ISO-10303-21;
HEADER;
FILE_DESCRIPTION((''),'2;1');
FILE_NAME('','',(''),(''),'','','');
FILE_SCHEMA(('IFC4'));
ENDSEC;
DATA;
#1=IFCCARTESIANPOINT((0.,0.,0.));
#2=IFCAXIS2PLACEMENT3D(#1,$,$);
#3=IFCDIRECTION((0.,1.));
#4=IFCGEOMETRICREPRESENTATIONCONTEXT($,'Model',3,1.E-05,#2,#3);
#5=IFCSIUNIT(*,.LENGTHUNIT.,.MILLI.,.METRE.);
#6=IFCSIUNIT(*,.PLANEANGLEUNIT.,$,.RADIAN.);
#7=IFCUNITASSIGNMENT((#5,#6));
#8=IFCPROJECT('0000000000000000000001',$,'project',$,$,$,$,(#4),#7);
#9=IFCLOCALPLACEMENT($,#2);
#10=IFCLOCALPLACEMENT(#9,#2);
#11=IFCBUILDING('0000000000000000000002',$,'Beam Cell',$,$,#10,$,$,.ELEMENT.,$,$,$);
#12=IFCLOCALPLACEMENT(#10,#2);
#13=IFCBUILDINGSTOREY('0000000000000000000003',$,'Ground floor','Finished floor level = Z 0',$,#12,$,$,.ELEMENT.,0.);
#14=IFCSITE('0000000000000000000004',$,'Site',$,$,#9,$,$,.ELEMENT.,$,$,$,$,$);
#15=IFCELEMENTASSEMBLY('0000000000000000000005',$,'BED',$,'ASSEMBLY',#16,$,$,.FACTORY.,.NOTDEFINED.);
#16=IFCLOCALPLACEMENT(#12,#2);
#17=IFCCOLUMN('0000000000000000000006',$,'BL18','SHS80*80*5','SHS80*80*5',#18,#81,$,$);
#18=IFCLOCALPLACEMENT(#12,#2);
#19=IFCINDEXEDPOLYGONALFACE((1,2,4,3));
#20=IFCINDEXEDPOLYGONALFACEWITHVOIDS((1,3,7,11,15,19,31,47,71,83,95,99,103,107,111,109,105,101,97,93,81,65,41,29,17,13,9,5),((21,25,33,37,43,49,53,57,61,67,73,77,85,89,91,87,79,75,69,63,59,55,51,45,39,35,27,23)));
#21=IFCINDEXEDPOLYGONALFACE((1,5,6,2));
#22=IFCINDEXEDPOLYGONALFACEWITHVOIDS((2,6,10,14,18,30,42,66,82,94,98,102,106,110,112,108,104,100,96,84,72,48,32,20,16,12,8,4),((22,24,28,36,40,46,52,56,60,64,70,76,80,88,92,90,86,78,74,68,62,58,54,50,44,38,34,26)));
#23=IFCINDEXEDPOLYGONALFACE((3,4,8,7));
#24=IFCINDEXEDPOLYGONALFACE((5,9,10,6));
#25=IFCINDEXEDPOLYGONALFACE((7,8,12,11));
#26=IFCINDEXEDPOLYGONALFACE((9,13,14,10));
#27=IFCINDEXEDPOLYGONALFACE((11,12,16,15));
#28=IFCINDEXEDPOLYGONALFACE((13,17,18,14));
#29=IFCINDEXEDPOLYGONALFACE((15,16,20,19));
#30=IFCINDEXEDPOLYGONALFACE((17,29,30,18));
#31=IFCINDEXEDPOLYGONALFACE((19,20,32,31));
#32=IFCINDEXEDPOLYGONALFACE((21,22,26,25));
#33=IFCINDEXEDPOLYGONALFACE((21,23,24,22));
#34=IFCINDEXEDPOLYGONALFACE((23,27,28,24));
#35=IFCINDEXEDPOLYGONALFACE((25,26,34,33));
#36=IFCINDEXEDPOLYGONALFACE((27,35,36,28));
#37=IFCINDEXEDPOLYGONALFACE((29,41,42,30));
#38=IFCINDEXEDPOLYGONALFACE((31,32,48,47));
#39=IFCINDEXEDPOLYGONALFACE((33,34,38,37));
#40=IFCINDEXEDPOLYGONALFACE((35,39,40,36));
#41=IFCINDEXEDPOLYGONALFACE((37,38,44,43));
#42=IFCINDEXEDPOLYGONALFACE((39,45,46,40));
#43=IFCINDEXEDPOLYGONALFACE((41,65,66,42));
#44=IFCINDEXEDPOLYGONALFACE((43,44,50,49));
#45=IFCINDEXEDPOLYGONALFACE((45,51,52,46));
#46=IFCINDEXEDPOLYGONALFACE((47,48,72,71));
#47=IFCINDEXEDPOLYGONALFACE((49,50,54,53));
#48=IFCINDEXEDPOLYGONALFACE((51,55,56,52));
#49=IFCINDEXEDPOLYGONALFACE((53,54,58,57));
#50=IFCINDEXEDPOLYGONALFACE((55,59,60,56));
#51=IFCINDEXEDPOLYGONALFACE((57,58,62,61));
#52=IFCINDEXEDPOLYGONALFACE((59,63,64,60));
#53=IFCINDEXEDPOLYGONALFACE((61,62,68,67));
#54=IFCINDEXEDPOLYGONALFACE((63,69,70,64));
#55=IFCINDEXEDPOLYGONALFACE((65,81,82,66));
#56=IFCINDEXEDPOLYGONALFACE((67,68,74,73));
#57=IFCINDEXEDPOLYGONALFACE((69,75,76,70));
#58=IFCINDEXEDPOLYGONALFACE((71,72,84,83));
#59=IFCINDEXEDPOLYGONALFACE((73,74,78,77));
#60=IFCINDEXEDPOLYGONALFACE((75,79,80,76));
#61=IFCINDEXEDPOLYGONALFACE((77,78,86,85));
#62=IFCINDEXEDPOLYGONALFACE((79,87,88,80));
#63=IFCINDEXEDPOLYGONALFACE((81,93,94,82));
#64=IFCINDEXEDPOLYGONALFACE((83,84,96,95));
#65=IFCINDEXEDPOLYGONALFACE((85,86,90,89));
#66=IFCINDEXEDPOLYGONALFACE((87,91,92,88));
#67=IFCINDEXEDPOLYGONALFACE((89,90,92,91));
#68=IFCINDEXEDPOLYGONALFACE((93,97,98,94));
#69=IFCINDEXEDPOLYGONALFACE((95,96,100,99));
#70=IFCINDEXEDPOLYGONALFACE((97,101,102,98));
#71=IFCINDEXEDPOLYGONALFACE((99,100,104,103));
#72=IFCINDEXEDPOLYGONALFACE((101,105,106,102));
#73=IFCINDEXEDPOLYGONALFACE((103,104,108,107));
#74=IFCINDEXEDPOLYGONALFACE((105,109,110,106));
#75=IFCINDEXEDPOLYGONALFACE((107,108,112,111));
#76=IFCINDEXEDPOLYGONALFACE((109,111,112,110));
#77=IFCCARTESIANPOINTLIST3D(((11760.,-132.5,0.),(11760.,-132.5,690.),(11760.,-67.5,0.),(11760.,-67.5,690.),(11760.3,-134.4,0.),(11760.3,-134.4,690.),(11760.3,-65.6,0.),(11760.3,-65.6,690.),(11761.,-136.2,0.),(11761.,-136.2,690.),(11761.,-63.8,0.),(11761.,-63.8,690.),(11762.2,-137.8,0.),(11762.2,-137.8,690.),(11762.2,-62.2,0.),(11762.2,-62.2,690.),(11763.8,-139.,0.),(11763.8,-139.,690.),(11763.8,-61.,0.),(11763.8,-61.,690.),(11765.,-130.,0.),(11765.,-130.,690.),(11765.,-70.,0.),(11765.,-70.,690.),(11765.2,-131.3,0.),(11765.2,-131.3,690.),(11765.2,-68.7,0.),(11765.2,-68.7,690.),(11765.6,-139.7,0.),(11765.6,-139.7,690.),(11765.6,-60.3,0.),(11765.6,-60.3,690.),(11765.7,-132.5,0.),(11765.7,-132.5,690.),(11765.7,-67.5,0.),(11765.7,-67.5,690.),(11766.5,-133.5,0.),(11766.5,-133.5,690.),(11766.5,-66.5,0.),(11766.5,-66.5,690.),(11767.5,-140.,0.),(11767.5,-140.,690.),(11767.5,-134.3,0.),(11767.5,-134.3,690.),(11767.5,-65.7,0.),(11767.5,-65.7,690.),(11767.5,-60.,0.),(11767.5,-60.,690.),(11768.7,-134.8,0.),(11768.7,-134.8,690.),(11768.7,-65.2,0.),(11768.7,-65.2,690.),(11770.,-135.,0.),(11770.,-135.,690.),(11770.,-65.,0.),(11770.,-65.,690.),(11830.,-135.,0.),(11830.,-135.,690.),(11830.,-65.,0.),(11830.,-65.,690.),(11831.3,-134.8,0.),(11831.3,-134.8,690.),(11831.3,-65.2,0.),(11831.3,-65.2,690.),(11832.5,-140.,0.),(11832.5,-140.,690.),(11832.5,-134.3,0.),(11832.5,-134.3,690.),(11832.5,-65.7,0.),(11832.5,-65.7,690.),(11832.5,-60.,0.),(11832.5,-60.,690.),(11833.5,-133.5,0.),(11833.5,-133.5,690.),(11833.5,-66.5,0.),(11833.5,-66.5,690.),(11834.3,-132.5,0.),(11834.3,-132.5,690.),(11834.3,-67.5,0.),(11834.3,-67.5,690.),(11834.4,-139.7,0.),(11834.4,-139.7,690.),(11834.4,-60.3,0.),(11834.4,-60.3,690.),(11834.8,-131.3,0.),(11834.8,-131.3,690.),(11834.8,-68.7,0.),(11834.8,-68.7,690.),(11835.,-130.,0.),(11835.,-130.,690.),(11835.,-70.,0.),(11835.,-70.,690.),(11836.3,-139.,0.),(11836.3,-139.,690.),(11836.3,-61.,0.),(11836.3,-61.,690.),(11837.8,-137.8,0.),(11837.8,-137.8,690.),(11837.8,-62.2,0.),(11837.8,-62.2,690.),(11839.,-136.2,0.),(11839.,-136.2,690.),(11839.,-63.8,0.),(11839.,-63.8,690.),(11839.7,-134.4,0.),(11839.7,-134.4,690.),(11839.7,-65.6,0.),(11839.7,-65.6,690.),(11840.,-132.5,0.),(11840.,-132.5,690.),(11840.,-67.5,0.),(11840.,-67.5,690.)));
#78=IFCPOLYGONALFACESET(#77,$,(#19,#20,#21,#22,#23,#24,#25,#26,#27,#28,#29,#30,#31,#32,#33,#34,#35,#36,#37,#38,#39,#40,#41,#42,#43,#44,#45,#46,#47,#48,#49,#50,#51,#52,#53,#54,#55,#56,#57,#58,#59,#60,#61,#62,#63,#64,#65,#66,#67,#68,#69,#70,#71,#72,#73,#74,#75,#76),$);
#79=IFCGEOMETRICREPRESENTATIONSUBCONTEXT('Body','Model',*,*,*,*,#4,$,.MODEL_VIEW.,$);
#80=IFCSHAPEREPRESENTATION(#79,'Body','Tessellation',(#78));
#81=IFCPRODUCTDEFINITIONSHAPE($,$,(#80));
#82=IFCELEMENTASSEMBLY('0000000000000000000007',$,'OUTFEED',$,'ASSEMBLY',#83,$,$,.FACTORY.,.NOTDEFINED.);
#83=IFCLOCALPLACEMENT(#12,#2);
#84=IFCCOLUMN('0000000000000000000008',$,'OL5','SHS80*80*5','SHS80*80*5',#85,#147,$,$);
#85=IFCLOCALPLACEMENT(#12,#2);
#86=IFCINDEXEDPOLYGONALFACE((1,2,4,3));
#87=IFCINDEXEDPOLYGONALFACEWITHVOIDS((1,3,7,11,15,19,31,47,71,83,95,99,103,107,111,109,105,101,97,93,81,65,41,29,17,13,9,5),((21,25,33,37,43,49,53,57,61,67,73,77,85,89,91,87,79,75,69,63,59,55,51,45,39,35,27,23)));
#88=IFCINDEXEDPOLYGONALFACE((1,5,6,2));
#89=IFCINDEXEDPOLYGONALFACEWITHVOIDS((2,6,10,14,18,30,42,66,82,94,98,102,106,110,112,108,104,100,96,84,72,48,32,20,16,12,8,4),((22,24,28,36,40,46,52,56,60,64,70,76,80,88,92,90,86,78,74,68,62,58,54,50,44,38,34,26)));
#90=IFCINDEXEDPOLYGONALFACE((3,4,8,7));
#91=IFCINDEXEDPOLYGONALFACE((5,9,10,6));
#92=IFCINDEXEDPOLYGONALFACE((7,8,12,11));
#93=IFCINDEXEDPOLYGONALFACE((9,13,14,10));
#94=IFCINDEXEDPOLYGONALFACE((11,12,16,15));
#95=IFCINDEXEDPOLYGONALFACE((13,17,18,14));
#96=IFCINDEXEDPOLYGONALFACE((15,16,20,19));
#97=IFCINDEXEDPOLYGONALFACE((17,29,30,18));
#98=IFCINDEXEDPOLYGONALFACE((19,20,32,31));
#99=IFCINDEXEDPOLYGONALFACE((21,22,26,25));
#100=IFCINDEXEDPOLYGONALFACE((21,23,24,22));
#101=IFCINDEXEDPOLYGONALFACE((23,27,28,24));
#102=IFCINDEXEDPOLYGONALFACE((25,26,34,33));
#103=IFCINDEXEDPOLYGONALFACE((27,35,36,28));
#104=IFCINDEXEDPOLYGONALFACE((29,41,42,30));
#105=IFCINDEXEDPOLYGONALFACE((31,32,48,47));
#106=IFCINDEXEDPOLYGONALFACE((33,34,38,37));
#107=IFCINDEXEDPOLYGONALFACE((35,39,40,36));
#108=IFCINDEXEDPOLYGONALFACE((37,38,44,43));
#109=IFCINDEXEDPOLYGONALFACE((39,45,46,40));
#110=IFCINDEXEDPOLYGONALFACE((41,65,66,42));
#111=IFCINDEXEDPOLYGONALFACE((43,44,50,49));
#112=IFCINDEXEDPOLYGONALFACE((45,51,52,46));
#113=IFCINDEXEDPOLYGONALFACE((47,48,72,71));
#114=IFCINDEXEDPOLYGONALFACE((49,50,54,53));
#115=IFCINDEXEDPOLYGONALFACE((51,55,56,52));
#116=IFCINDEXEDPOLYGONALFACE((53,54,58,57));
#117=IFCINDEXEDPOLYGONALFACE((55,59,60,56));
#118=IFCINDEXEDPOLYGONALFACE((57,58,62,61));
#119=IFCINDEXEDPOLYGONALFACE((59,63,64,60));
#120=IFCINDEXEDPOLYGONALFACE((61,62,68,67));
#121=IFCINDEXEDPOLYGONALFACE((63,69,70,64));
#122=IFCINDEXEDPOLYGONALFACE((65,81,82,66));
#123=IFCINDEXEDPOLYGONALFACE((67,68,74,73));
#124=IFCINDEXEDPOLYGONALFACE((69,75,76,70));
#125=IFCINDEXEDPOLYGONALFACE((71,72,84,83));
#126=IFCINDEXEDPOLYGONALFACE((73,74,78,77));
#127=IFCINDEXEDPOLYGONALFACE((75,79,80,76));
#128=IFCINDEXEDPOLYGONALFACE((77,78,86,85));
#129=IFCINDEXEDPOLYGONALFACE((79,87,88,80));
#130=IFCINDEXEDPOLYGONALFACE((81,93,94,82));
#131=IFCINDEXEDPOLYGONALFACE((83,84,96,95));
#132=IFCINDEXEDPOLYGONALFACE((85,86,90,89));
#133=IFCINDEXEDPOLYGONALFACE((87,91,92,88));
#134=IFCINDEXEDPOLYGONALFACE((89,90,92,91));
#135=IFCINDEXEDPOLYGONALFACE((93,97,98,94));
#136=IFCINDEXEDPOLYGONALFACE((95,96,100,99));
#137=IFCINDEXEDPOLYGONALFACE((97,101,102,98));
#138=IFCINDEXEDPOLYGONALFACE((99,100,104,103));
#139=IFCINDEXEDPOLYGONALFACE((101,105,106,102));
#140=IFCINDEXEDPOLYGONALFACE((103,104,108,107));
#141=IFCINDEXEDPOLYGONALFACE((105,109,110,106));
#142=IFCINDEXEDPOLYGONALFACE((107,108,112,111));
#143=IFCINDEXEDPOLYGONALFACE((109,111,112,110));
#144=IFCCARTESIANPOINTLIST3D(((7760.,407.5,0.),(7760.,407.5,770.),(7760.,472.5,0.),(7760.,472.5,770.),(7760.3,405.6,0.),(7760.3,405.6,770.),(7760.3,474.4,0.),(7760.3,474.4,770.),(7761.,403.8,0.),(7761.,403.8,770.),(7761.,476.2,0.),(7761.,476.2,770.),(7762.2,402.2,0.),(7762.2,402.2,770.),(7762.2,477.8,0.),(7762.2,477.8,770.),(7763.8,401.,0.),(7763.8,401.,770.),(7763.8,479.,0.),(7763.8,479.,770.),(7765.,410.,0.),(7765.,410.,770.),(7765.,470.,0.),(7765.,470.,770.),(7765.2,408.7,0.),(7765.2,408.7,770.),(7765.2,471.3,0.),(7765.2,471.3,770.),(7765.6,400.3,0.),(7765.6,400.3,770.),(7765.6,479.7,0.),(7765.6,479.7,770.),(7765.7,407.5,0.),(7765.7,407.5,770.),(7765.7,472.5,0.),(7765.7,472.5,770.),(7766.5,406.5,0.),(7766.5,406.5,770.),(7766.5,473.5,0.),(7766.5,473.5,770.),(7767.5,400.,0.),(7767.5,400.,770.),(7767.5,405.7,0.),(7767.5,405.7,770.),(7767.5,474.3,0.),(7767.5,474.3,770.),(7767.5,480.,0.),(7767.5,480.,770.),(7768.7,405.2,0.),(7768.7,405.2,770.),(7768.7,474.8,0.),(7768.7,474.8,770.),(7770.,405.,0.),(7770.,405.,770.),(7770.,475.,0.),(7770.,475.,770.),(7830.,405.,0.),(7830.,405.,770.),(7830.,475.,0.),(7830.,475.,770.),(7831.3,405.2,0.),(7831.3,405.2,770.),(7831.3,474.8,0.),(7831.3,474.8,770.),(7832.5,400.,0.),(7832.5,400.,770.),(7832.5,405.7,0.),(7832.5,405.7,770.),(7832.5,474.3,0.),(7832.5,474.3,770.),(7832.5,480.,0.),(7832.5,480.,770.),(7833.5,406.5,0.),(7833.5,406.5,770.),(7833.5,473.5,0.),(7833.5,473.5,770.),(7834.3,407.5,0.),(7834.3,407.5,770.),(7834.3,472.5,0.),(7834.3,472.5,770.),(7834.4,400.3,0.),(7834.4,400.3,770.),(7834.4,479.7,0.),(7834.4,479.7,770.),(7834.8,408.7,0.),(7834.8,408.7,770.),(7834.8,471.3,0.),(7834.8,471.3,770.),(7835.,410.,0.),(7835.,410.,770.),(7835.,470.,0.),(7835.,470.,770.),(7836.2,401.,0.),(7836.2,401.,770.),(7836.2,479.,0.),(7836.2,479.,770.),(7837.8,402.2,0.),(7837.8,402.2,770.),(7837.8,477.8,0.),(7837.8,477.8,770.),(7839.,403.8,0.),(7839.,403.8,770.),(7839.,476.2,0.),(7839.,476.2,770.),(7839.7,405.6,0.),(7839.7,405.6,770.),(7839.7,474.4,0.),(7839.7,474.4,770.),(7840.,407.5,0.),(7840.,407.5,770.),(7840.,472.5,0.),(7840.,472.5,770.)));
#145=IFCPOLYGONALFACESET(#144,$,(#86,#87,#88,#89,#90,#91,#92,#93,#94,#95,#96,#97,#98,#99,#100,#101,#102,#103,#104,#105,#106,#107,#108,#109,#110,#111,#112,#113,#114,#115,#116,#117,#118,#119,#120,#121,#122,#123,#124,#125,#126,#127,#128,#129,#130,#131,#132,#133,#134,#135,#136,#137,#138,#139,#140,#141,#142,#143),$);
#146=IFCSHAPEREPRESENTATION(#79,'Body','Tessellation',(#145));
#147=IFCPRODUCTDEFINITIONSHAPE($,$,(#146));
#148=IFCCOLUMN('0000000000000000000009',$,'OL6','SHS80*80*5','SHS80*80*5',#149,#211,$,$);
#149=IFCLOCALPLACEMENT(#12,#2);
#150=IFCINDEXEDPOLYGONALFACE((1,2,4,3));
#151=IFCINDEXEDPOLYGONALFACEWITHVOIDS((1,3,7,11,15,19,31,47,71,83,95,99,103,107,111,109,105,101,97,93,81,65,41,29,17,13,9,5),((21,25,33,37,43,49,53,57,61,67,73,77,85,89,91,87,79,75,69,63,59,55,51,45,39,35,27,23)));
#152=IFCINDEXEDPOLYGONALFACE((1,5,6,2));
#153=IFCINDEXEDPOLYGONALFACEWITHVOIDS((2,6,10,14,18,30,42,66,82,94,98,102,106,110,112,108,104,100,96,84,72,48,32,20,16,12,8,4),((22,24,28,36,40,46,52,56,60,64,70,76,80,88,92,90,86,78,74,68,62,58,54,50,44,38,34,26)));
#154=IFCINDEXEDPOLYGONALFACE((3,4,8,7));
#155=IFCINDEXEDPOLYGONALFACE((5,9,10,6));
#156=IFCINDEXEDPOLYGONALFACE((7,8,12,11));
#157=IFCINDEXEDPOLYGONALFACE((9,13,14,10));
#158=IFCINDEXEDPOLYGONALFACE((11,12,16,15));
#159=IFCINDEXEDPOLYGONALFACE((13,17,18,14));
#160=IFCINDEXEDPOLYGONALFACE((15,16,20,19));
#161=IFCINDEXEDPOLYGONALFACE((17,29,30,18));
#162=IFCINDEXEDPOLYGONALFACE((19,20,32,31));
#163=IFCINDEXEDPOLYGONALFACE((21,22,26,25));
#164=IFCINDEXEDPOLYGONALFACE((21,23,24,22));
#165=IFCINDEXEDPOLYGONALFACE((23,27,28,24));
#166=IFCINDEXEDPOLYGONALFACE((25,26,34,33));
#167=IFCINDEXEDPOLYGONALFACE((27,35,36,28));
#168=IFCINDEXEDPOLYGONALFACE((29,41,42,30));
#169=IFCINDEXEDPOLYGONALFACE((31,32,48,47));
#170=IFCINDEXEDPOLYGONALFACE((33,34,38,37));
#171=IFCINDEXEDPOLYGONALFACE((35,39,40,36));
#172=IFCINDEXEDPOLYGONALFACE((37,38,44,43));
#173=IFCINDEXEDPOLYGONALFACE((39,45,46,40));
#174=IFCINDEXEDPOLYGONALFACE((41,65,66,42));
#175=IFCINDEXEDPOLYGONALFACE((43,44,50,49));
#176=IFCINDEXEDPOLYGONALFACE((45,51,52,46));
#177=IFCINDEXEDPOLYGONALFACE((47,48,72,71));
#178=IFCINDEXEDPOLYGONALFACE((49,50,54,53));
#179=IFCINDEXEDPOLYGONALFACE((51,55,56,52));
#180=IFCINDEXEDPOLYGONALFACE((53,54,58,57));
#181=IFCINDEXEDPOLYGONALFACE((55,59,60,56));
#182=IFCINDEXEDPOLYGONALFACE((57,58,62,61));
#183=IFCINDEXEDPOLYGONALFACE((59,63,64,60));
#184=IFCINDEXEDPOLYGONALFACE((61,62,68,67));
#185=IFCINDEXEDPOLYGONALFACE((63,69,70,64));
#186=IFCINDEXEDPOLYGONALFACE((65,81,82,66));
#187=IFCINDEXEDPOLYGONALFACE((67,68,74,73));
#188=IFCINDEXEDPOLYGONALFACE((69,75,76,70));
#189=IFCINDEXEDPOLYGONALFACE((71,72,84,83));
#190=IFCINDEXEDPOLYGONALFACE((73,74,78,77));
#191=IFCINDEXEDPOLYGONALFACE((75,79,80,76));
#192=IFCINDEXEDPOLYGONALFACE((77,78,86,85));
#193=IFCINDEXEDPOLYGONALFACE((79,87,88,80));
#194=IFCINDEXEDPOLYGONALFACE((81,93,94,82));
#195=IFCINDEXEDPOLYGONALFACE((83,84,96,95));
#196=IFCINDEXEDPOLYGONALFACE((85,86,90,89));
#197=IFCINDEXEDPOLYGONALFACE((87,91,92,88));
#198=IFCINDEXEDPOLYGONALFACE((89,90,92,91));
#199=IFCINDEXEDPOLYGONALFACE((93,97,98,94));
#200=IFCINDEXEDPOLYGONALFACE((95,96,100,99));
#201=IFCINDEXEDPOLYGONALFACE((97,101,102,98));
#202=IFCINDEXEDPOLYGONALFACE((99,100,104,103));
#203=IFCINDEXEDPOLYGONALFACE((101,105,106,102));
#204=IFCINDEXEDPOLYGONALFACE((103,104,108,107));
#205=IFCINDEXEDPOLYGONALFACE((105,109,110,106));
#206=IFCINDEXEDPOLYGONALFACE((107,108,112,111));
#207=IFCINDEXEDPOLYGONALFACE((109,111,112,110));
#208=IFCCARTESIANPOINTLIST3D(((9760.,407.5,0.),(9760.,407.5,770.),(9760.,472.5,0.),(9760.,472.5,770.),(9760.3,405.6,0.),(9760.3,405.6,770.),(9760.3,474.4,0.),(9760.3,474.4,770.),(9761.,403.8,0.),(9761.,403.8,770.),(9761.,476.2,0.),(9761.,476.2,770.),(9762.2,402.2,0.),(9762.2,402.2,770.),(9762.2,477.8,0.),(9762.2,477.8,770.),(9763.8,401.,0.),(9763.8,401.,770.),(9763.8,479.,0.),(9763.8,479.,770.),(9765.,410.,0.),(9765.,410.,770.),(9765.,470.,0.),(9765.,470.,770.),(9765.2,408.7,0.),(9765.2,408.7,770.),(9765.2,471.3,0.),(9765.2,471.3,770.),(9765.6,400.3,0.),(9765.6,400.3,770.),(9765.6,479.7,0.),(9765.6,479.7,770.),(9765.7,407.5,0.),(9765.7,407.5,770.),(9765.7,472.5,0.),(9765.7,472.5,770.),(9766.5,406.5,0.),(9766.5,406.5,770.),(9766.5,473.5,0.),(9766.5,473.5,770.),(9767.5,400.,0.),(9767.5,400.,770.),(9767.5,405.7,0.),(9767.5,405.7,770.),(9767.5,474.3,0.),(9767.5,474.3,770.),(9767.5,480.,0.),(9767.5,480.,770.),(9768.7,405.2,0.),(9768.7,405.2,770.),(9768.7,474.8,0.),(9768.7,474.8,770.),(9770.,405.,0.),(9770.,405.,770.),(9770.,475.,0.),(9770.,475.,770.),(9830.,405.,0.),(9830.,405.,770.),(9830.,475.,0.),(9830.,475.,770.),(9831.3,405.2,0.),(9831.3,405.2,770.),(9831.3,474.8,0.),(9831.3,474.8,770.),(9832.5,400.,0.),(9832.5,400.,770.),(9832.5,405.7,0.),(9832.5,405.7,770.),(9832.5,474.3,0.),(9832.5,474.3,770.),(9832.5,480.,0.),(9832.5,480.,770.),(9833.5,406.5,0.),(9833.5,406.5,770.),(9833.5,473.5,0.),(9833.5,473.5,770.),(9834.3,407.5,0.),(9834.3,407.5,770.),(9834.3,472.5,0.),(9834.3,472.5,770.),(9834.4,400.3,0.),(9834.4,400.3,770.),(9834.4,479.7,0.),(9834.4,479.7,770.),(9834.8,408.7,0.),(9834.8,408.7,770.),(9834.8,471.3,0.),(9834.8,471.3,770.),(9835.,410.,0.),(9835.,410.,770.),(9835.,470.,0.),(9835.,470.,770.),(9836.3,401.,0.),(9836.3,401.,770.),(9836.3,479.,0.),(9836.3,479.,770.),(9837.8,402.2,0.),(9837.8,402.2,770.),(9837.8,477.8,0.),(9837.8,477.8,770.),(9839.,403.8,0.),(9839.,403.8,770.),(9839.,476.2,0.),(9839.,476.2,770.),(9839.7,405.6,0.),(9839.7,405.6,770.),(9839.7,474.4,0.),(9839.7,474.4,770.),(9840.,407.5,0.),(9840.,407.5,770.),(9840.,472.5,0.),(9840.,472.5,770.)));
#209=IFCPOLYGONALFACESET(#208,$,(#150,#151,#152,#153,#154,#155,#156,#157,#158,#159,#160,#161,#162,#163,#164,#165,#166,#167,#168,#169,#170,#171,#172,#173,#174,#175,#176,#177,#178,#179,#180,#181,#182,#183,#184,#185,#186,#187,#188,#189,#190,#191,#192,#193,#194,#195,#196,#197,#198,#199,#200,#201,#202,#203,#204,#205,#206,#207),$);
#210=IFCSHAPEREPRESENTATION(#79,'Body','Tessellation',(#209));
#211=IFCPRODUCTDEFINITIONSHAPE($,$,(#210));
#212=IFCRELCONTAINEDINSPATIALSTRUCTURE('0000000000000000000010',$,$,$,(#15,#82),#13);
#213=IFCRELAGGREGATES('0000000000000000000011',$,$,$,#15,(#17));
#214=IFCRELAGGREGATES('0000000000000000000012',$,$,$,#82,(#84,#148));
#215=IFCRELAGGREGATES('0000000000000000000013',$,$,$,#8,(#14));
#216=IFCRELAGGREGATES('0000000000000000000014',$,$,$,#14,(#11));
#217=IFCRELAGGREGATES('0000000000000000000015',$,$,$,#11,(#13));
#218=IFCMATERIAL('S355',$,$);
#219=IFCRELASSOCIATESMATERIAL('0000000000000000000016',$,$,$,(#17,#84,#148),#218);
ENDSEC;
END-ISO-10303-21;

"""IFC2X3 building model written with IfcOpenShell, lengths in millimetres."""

from ifc_helpers import new_model, si_unit, direction, frame, origin, origin_2d, place, context, subcontext, project, spatial, hollow_rectangle, extrude, material, element, aggregate, save


model = new_model("IFC2X3")

# Units and contexts
model_context = context("Model", 3, precision=1e-05, world=origin(), true_north=direction((0.0, 1.0)))
body_context = subcontext(model_context, "Body", "Model", "MODEL_VIEW")
ifc_project = project(units=[si_unit("LENGTHUNIT", "METRE", prefix="MILLI"), si_unit("PLANEANGLEUNIT", "RADIAN")], contexts=[model_context])

# Site, building, storey
site_placement = place(None, origin())
site = spatial("IfcSite", under=ifc_project, at=site_placement, Name="Site", CompositionType="ELEMENT")
building_placement = place(site_placement, origin())
building = spatial("IfcBuilding", under=site, at=building_placement, Name="Beam Cell", CompositionType="ELEMENT")
storey_placement = place(building_placement, origin())
storey = spatial("IfcBuildingStorey", under=building, at=storey_placement, Name="Ground floor", Description="Finished floor level = Z 0", CompositionType="ELEMENT", Elevation=0.0)

# Element assemblies, columns
ifc_material = material(Name="S355")
assembly_1_placement = place(storey_placement, origin())
assembly_1 = element("IfcElementAssembly", 1, at=assembly_1_placement, inside=storey, Name="BED", ObjectType="ASSEMBLY", AssemblyPlace="FACTORY", PredefinedType="NOTDEFINED")
column_1_placement = place(storey_placement, frame((11800.0, -100.0, 0.0), z_axis=(0.0, 0.0, 1.0), x_axis=(1.0, 0.0, 0.0)))
column_1 = element("IfcColumn", 2, at=column_1_placement, material=ifc_material, Name="BL18", Description="SHS80*80*5", ObjectType="SHS80*80*5", context=body_context, shape_type="SweptSolid", body=[
    extrude(hollow_rectangle(XDim=80.0, YDim=80.0, WallThickness=5.0, InnerFilletRadius=5.0, OuterFilletRadius=7.5, at=origin_2d()), origin(), (0.0, 0.0, 1.0), 690.0),
])
assembly_2_placement = place(storey_placement, origin())
assembly_2 = element("IfcElementAssembly", 3, at=assembly_2_placement, inside=storey, Name="OUTFEED", ObjectType="ASSEMBLY", AssemblyPlace="FACTORY", PredefinedType="NOTDEFINED")
column_2_placement = place(storey_placement, frame((7800.0, 440.0, 0.0), z_axis=(0.0, 0.0, 1.0), x_axis=(1.0, 0.0, 0.0)))
column_2 = element("IfcColumn", 4, at=column_2_placement, material=ifc_material, Name="OL5", Description="SHS80*80*5", ObjectType="SHS80*80*5", context=body_context, shape_type="SweptSolid", body=[
    extrude(hollow_rectangle(XDim=80.0, YDim=80.0, WallThickness=5.0, InnerFilletRadius=5.0, OuterFilletRadius=7.5, at=origin_2d()), origin(), (0.0, 0.0, 1.0), 770.0),
])
column_3_placement = place(storey_placement, frame((9800.0, 440.0, 0.0), z_axis=(0.0, 0.0, 1.0), x_axis=(1.0, 0.0, 0.0)))
column_3 = element("IfcColumn", 5, at=column_3_placement, material=ifc_material, Name="OL6", Description="SHS80*80*5", ObjectType="SHS80*80*5", context=body_context, shape_type="SweptSolid", body=[
    extrude(hollow_rectangle(XDim=80.0, YDim=80.0, WallThickness=5.0, InnerFilletRadius=5.0, OuterFilletRadius=7.5, at=origin_2d()), origin(), (0.0, 0.0, 1.0), 770.0),
])

aggregate(assembly_1, [column_1])
aggregate(assembly_2, [column_2, column_3])

save(model, "model.ifc")
